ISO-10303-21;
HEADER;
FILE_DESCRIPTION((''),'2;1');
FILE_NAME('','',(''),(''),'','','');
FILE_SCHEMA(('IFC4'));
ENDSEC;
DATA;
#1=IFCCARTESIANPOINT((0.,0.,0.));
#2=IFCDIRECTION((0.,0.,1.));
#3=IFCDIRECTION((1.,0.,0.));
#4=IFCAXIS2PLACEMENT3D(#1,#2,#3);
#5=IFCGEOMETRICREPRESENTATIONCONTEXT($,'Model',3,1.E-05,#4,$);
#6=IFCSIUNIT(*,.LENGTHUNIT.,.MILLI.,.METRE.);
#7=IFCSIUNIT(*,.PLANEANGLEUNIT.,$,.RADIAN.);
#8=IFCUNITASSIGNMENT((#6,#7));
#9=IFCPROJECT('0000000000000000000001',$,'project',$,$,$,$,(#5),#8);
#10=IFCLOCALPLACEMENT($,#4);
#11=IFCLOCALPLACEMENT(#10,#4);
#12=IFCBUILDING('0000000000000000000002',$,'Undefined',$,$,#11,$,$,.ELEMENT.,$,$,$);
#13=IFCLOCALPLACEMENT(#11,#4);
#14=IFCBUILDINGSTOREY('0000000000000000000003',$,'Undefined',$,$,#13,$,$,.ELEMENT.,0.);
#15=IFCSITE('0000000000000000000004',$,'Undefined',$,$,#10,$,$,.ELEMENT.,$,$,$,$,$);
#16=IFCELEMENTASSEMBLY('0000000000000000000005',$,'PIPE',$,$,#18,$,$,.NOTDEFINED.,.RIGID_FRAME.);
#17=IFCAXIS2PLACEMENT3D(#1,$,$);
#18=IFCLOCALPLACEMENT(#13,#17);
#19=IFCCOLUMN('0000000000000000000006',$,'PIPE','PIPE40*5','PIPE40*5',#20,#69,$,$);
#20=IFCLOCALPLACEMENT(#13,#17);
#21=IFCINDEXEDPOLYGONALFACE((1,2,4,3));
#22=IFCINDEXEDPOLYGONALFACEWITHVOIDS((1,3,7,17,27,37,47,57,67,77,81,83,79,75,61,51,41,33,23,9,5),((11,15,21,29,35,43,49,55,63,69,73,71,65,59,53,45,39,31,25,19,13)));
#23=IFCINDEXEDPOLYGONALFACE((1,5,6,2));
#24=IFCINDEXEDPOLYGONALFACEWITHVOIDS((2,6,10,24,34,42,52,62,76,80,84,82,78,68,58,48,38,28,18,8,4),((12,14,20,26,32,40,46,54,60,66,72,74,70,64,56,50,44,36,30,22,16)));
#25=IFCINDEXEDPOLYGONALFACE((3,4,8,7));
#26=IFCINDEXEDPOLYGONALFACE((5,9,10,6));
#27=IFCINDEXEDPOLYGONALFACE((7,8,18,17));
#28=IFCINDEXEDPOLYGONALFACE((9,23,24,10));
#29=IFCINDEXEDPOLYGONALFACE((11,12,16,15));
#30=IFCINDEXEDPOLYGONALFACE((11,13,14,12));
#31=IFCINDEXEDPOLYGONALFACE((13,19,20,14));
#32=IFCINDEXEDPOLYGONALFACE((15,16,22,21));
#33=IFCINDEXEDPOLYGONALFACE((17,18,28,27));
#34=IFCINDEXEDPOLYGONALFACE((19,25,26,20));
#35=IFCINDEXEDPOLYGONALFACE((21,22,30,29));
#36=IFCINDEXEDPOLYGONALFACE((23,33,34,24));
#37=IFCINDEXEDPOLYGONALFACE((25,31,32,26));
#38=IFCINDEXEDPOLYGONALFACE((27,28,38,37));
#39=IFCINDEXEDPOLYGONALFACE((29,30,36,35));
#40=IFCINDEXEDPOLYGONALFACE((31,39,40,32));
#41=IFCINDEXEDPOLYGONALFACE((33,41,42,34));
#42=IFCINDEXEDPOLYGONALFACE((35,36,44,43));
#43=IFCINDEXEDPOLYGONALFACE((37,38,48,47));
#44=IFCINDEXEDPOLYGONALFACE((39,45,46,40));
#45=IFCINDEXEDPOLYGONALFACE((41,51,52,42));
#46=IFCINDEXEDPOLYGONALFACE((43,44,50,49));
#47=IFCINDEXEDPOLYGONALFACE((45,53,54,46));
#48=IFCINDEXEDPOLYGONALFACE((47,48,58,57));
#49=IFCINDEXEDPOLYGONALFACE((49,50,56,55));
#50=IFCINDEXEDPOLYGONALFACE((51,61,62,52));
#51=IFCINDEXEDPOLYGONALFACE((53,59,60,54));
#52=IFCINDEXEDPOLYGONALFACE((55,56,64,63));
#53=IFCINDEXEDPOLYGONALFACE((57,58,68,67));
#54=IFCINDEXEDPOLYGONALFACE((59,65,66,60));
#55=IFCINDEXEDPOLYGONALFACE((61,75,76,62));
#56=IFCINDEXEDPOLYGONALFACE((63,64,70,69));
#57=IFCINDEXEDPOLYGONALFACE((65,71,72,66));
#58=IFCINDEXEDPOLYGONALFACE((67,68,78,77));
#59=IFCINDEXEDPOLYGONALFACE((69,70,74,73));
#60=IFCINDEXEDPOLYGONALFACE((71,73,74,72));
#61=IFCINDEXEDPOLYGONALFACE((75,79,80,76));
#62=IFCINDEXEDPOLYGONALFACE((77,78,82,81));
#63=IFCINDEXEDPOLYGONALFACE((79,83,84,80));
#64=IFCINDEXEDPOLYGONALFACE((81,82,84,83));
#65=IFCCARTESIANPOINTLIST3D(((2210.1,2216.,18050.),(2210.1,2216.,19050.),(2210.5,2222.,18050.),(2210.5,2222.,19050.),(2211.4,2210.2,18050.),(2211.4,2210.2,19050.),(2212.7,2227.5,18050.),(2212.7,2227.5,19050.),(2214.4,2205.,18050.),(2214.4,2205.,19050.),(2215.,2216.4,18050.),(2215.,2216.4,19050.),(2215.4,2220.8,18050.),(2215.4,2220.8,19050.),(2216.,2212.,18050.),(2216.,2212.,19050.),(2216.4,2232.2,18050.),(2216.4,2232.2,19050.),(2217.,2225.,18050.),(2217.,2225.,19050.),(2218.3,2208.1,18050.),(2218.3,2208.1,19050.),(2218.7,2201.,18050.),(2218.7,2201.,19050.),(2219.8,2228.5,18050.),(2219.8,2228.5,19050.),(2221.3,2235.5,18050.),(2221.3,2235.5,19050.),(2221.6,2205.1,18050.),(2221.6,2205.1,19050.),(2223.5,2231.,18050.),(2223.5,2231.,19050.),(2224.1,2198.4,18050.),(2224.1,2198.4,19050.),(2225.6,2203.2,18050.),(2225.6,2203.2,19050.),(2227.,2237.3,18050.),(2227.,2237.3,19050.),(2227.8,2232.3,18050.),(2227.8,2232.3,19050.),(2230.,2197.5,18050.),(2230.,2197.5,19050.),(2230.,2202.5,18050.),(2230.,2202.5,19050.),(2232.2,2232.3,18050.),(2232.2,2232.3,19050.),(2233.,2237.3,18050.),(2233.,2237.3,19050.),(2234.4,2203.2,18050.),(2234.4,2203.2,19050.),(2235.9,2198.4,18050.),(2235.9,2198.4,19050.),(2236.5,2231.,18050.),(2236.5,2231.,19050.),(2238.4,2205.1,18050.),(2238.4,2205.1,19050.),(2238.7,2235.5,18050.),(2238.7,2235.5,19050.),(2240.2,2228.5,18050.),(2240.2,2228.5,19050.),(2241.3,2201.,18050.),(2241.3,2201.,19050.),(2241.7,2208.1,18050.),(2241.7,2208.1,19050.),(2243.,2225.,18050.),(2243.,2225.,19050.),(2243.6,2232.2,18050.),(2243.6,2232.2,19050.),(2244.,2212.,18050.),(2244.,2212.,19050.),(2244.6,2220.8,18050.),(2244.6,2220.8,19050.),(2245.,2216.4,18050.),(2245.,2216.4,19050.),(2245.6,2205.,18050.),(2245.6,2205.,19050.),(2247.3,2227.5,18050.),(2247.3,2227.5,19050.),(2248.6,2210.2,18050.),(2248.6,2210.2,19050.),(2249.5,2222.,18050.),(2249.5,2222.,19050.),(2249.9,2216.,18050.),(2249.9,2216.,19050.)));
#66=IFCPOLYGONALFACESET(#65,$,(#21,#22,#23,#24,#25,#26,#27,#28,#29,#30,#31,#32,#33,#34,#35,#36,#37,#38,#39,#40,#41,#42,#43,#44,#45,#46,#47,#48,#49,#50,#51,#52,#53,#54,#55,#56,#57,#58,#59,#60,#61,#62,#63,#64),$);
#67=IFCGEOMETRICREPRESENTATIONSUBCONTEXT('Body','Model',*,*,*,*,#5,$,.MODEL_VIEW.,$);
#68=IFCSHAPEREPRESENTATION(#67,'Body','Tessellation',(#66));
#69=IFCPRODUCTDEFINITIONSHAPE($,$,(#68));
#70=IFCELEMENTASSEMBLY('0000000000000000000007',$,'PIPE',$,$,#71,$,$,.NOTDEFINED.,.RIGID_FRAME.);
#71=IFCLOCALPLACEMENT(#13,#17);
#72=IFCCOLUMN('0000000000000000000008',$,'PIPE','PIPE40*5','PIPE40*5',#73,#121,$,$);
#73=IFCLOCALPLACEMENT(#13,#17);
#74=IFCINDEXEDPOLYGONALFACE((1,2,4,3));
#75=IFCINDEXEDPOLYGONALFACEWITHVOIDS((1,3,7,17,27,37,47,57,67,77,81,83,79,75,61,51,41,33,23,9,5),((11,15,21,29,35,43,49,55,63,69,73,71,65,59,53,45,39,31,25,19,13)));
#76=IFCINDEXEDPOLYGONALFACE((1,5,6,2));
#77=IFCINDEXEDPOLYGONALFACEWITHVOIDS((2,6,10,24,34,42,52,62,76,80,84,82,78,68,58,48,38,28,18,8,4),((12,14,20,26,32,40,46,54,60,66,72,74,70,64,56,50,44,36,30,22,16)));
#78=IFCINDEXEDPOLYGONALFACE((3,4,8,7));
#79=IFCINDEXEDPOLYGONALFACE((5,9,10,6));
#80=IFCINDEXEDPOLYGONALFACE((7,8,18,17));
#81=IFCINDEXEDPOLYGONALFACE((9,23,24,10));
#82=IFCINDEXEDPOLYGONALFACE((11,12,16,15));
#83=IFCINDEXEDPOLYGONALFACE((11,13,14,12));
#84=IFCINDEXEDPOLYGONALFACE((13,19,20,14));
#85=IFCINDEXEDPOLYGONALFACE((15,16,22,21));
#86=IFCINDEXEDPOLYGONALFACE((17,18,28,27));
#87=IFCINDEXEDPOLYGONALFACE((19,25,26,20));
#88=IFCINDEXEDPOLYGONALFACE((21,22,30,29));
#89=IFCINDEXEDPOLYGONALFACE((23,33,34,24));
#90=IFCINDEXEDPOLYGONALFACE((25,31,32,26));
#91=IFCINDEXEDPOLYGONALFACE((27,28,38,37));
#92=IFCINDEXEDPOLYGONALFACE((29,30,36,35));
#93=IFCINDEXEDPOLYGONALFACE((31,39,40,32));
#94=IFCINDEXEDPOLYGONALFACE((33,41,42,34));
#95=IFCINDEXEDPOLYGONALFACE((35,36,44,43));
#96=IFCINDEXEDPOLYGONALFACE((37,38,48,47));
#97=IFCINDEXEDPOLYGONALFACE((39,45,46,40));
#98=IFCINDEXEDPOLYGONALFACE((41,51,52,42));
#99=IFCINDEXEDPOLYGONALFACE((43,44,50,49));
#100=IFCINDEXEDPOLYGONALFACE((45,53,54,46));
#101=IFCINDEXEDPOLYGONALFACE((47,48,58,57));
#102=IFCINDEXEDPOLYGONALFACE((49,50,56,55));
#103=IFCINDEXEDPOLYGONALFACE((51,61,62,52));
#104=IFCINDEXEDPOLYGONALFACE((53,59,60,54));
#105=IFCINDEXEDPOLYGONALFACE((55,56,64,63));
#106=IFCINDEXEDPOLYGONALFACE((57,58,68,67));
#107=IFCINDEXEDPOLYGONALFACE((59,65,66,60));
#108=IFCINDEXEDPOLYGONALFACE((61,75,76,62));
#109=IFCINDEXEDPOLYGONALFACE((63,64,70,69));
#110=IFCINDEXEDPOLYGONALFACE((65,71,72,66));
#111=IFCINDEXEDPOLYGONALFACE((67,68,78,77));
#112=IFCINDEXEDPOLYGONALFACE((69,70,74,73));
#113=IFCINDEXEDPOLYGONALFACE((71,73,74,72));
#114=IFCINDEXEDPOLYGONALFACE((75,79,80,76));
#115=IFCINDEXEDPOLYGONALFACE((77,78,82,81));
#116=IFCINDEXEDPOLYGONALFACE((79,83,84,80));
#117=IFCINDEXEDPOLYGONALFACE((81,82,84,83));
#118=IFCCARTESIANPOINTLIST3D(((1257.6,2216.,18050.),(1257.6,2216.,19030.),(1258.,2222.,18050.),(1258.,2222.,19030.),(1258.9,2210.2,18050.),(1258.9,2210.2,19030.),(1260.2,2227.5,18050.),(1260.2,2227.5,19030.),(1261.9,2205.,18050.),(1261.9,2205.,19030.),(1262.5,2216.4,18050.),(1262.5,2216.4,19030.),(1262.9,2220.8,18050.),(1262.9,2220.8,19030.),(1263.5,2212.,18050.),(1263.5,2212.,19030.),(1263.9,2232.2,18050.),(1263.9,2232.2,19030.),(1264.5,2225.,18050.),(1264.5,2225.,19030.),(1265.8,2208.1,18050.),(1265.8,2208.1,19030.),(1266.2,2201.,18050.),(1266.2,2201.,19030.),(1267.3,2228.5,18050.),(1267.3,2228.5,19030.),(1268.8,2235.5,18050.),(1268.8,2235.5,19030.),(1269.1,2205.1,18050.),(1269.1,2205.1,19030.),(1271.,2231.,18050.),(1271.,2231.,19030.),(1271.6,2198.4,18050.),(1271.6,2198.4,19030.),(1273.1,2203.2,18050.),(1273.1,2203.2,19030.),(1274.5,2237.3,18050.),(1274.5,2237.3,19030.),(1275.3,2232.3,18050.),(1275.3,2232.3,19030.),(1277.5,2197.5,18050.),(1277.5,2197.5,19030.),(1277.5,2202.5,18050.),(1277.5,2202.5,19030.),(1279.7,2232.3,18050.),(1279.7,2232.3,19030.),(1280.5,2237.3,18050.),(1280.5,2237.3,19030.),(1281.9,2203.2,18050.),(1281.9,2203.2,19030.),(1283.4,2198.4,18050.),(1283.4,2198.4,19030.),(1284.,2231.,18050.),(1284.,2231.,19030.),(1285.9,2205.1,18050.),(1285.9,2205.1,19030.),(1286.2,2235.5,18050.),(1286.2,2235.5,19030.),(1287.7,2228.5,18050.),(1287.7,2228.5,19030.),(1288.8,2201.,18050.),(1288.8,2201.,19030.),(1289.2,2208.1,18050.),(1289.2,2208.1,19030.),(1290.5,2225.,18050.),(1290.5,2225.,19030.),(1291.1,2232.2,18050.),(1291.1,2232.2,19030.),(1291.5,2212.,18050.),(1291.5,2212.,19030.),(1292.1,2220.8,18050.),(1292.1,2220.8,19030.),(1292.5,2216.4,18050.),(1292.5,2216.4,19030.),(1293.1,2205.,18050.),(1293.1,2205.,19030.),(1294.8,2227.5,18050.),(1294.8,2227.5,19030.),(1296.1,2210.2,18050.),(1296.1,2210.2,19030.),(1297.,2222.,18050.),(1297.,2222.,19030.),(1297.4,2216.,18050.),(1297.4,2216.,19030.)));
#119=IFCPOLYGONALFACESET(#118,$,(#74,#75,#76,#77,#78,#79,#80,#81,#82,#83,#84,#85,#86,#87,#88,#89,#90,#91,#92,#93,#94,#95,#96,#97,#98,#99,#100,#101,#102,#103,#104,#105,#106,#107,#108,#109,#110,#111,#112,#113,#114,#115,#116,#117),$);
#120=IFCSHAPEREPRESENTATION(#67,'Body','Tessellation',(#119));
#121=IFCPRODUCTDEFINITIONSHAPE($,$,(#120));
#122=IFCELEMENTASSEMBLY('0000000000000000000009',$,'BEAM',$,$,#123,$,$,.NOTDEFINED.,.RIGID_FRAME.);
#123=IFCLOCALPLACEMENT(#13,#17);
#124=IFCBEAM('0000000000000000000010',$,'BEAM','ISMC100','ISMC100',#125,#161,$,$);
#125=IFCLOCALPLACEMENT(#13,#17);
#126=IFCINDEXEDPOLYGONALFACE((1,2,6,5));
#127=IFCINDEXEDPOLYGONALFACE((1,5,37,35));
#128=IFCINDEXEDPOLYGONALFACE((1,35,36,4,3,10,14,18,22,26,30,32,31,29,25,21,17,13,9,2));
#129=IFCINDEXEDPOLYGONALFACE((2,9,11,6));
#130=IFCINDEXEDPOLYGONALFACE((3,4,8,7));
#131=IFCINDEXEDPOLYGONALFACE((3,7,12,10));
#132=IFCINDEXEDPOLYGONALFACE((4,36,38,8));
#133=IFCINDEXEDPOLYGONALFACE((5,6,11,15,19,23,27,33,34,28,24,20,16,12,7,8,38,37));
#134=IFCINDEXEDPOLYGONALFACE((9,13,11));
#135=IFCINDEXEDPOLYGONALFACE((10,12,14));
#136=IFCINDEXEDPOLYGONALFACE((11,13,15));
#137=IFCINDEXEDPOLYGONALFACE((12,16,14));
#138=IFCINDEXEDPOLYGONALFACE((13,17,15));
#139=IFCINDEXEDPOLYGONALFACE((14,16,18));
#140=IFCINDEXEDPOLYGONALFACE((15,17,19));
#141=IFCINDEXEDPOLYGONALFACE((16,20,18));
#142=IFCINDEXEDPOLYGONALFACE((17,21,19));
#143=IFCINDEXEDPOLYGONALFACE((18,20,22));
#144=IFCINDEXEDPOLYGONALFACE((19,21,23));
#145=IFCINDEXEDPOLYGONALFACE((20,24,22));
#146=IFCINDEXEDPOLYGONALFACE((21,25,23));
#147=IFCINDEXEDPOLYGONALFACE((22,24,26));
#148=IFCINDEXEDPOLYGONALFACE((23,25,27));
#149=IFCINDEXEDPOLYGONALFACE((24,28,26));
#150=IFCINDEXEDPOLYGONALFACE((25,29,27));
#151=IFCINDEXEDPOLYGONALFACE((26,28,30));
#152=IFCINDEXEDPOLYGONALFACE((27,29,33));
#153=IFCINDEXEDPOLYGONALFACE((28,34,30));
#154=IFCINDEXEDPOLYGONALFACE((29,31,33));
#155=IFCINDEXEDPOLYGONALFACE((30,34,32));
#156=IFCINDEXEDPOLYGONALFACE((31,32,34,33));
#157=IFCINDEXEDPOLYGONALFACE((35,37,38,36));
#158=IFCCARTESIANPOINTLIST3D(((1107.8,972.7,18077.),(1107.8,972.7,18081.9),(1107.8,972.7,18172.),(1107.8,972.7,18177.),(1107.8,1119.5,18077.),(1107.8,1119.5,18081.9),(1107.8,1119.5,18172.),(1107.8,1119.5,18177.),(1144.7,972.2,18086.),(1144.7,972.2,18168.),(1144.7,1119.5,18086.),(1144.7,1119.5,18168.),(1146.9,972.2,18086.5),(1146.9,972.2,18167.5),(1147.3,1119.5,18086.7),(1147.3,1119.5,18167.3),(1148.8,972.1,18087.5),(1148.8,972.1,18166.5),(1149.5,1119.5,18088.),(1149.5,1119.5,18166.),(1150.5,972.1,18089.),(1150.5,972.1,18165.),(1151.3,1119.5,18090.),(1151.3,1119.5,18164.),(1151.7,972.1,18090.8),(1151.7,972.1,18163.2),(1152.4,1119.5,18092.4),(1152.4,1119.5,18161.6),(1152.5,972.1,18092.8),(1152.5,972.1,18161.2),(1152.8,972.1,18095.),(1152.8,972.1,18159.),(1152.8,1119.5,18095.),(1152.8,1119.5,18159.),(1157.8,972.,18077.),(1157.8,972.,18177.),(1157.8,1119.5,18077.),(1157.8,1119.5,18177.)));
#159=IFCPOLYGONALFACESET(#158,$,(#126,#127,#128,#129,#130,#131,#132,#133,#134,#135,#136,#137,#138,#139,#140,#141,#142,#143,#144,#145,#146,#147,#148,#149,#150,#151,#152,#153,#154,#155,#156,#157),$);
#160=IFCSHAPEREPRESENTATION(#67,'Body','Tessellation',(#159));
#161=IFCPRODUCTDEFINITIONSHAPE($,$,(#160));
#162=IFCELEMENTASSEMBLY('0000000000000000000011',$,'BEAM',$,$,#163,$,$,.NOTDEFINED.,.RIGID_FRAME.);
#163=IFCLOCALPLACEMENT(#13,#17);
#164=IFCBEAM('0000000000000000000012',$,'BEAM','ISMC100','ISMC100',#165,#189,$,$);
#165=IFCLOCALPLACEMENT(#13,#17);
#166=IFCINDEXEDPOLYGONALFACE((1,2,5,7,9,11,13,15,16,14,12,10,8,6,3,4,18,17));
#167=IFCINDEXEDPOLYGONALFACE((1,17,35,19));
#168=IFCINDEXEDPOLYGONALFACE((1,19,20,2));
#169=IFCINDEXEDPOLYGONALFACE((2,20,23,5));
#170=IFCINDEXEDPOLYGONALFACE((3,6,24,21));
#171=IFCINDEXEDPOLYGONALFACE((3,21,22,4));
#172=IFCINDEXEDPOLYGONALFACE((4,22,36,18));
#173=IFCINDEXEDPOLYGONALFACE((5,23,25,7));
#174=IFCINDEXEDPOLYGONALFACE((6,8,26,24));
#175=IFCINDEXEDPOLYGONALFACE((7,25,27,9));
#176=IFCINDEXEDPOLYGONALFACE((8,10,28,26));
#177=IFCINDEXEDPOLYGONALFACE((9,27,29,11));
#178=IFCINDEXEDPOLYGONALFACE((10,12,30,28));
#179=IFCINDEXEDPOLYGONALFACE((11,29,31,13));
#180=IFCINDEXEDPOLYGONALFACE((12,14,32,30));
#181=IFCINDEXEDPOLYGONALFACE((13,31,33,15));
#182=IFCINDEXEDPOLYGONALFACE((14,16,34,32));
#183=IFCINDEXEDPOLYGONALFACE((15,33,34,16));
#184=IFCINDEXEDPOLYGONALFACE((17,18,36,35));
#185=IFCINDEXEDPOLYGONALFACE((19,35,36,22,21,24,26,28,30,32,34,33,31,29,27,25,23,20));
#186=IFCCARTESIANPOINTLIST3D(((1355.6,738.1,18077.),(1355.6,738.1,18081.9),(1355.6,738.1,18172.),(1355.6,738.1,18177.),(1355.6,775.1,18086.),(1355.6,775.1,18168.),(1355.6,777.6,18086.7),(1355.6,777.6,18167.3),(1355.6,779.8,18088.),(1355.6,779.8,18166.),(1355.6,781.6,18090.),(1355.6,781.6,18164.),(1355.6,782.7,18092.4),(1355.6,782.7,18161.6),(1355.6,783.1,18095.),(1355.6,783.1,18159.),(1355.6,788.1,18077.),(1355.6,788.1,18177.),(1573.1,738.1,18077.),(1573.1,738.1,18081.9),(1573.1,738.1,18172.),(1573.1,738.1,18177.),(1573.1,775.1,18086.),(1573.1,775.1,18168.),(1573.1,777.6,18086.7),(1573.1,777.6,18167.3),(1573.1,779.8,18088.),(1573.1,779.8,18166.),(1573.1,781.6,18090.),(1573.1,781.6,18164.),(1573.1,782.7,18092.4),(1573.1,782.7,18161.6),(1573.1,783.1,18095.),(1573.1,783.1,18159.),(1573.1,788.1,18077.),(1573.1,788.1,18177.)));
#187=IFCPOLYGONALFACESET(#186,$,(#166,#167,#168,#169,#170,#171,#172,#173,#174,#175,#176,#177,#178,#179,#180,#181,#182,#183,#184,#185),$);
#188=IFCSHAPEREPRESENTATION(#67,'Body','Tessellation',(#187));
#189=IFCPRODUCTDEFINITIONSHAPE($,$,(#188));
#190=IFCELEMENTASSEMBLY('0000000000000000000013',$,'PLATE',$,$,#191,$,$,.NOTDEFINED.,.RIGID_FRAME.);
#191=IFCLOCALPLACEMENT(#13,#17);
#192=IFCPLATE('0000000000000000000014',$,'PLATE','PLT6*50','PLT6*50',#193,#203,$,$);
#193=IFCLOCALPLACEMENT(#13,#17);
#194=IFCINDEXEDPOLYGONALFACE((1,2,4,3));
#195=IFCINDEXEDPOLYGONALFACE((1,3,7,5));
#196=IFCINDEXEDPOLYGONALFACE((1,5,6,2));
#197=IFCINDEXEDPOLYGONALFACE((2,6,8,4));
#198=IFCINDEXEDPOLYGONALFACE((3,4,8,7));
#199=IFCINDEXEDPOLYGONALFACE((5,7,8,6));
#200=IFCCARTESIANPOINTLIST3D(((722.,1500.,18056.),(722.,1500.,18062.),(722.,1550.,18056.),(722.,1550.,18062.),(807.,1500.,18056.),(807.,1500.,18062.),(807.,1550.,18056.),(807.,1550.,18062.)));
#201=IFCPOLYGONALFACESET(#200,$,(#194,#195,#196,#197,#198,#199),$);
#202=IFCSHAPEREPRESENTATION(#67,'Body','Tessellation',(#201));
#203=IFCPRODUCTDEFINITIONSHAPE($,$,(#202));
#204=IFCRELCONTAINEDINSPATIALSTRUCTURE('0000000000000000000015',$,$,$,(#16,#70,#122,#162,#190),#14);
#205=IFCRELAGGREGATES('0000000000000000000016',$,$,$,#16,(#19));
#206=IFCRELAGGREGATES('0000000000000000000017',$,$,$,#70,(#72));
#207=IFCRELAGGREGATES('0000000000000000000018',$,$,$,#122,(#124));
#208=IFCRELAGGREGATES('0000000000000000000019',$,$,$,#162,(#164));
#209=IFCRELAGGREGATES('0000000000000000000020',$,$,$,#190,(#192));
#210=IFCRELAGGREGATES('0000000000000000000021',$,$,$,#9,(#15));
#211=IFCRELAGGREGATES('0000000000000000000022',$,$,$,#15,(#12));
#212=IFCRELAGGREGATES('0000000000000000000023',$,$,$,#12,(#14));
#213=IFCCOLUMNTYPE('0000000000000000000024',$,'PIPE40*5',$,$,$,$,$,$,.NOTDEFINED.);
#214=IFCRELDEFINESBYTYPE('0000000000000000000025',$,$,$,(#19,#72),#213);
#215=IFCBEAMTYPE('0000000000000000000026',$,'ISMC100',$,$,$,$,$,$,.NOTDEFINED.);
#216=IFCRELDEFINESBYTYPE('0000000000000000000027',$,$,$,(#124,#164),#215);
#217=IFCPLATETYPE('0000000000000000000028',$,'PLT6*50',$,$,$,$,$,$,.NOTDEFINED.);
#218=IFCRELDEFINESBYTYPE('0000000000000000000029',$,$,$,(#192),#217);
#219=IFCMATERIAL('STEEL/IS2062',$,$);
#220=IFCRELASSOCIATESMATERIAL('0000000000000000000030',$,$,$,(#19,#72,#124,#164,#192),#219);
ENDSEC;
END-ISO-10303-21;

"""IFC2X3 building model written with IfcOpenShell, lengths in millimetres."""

from ifc_helpers import new_model, si_unit, frame, origin_with_axes, origin_2d_with_axis, place, context, subcontext, project, spatial, polyline, hollow_circle, u_section, outline, extrude, clip, halfspace, material, type_object, element, aggregate, save


model = new_model("IFC2X3")

# Units and contexts
model_context = context("Model", 3, precision=1e-05, world=origin_with_axes())
body_context = subcontext(model_context, "Body", "Model", "MODEL_VIEW")
ifc_project = project(units=[si_unit("LENGTHUNIT", "METRE", prefix="MILLI"), si_unit("PLANEANGLEUNIT", "RADIAN")], contexts=[model_context])

# Site, building, storey
site_placement = place(None, origin_with_axes())
site = spatial("IfcSite", under=ifc_project, at=site_placement, Name="Undefined", CompositionType="ELEMENT")
building_placement = place(site_placement, origin_with_axes())
building = spatial("IfcBuilding", under=site, at=building_placement, Name="Undefined", CompositionType="ELEMENT")
storey_placement = place(building_placement, origin_with_axes())
storey = spatial("IfcBuildingStorey", under=building, at=storey_placement, Name="Undefined", CompositionType="ELEMENT", Elevation=0.0)

# Element assemblies, columns
ifc_material_1 = material(Name="STEEL/IS2062")
column_type_1 = type_object("IfcColumnType", Name="PIPE40*5", PredefinedType="NOTDEFINED")
assembly_1_placement = place(storey_placement, origin_with_axes())
assembly_1 = element("IfcElementAssembly", 1, at=assembly_1_placement, inside=storey, Name="PIPE", AssemblyPlace="NOTDEFINED", PredefinedType="RIGID_FRAME")
column_1_placement = place(assembly_1_placement, frame((2230.0, 2217.5, 18050.0), z_axis=(0.0, 0.0, 1.0), x_axis=(-1.0, 0.0, 0.0)))
column_1 = element("IfcColumn", 2, at=column_1_placement, type_object=column_type_1, material=ifc_material_1, Name="PIPE", Description="PIPE40*5", ObjectType="PIPE40*5", context=body_context, shape_type="SweptSolid", body=[
    extrude(hollow_circle(Radius=20.0, WallThickness=5.0, at=origin_2d_with_axis()), frame((0.0, 0.0, 1000.0), z_axis=(0.0, 0.0, -1.0), x_axis=(0.0, 1.0, 0.0)), (0.0, 0.0, 1.0), 1000.0),
])
aggregate(assembly_1, [column_1])
assembly_2_placement = place(storey_placement, origin_with_axes())
assembly_2 = element("IfcElementAssembly", 3, at=assembly_2_placement, inside=storey, Name="PIPE", AssemblyPlace="NOTDEFINED", PredefinedType="RIGID_FRAME")
column_2_placement = place(assembly_2_placement, frame((1277.5, 2217.5, 18050.0), z_axis=(0.0, 0.0, 1.0), x_axis=(-1.0, 0.0, 0.0)))
column_2 = element("IfcColumn", 4, at=column_2_placement, type_object=column_type_1, material=ifc_material_1, Name="PIPE", Description="PIPE40*5", ObjectType="PIPE40*5", context=body_context, shape_type="Clipping", body=[
    clip(extrude(hollow_circle(Radius=20.0, WallThickness=5.0, at=origin_2d_with_axis()), frame((0.0, 0.0, 1000.0), z_axis=(0.0, 0.0, -1.0), x_axis=(0.0, 1.0, 0.0)), (0.0, 0.0, 1.0), 1000.0), halfspace(frame((0.0, 0.0, 980.0), z_axis=(0.0, 0.0, 1.0), x_axis=(1.0, 0.0, 0.0)), False)),
])
aggregate(assembly_2, [column_2])

# Element assemblies, beams
assembly_3_placement = place(storey_placement, origin_with_axes())
assembly_3 = element("IfcElementAssembly", 5, at=assembly_3_placement, inside=storey, Name="BEAM", AssemblyPlace="NOTDEFINED", PredefinedType="RIGID_FRAME")
beam_type = type_object("IfcBeamType", Name="ISMC100", PredefinedType="NOTDEFINED")
beam_1_placement = place(assembly_3_placement, frame((1132.8, 972.0, 18127.0), z_axis=(0.0, 0.0, -1.0), x_axis=(0.0, 1.0, 0.0)))
beam_1 = element("IfcBeam", 6, at=beam_1_placement, type_object=beam_type, material=ifc_material_1, Name="BEAM", Description="ISMC100", ObjectType="ISMC100", context=body_context, shape_type="Clipping", body=[
    clip(extrude(u_section(Depth=100.0, FlangeWidth=50.0, WebThickness=5.0, FlangeThickness=7.7, FilletRadius=9.0, FlangeSlope=0.10956, at=origin_2d_with_axis()), frame((147.5, 0.0, 0.0), z_axis=(-1.0, 0.0, 0.0), x_axis=(0.0, -1.0, 0.0)), (0.0, 0.0, 1.0), 147.5), halfspace(frame((0.0, 25.0, -50.0), z_axis=(-0.999902, -0.013997, 0.0), x_axis=(0.0, 0.0, 1.0)), False)),
])
aggregate(assembly_3, [beam_1])
assembly_4_placement = place(storey_placement, origin_with_axes())
assembly_4 = element("IfcElementAssembly", 7, at=assembly_4_placement, inside=storey, Name="BEAM", AssemblyPlace="NOTDEFINED", PredefinedType="RIGID_FRAME")
beam_2_placement = place(assembly_4_placement, frame((1573.1, 763.1, 18127.0), z_axis=(0.0, 0.0, -1.0), x_axis=(-1.0, 0.0, 0.0)))
beam_2 = element("IfcBeam", 8, at=beam_2_placement, type_object=beam_type, material=ifc_material_1, Name="BEAM", Description="ISMC100", ObjectType="ISMC100", context=body_context, shape_type="SweptSolid", body=[
    extrude(u_section(Depth=100.0, FlangeWidth=50.0, WebThickness=5.0, FlangeThickness=7.7, FilletRadius=9.0, FlangeSlope=0.10956, at=origin_2d_with_axis()), frame((217.6, 0.0, 0.0), z_axis=(-1.0, 0.0, 0.0), x_axis=(0.0, -1.0, 0.0)), (0.0, 0.0, 1.0), 217.6),
])
aggregate(assembly_4, [beam_2])

# Element assembly, plate
assembly_5_placement = place(storey_placement, origin_with_axes())
assembly_5 = element("IfcElementAssembly", 9, at=assembly_5_placement, inside=storey, Name="PLATE", AssemblyPlace="NOTDEFINED", PredefinedType="RIGID_FRAME")
plate_type_1 = type_object("IfcPlateType", Name="PLT6*50", PredefinedType="NOTDEFINED")
plate_1_placement = place(assembly_5_placement, frame((807.0, 1550.0, 18059.0), z_axis=(0.0, 0.0, 1.0), x_axis=(-1.0, 0.0, 0.0)))
plate_1 = element("IfcPlate", 10, at=plate_1_placement, type_object=plate_type_1, material=ifc_material_1, Name="PLATE", Description="PLT6*50", ObjectType="PLT6*50", context=body_context, shape_type="SweptSolid", body=[
    extrude(outline(polyline([(0.0, 0.0), (85.0, 0.0), (85.0, 50.0), (0.0, 50.0), (0.0, 0.0)])), frame((0.0, 0.0, -3.0), z_axis=(0.0, 0.0, 1.0), x_axis=(1.0, 0.0, 0.0)), (0.0, 0.0, 1.0), 6.0),
])
aggregate(assembly_5, [plate_1])

save(model, "model.ifc")
